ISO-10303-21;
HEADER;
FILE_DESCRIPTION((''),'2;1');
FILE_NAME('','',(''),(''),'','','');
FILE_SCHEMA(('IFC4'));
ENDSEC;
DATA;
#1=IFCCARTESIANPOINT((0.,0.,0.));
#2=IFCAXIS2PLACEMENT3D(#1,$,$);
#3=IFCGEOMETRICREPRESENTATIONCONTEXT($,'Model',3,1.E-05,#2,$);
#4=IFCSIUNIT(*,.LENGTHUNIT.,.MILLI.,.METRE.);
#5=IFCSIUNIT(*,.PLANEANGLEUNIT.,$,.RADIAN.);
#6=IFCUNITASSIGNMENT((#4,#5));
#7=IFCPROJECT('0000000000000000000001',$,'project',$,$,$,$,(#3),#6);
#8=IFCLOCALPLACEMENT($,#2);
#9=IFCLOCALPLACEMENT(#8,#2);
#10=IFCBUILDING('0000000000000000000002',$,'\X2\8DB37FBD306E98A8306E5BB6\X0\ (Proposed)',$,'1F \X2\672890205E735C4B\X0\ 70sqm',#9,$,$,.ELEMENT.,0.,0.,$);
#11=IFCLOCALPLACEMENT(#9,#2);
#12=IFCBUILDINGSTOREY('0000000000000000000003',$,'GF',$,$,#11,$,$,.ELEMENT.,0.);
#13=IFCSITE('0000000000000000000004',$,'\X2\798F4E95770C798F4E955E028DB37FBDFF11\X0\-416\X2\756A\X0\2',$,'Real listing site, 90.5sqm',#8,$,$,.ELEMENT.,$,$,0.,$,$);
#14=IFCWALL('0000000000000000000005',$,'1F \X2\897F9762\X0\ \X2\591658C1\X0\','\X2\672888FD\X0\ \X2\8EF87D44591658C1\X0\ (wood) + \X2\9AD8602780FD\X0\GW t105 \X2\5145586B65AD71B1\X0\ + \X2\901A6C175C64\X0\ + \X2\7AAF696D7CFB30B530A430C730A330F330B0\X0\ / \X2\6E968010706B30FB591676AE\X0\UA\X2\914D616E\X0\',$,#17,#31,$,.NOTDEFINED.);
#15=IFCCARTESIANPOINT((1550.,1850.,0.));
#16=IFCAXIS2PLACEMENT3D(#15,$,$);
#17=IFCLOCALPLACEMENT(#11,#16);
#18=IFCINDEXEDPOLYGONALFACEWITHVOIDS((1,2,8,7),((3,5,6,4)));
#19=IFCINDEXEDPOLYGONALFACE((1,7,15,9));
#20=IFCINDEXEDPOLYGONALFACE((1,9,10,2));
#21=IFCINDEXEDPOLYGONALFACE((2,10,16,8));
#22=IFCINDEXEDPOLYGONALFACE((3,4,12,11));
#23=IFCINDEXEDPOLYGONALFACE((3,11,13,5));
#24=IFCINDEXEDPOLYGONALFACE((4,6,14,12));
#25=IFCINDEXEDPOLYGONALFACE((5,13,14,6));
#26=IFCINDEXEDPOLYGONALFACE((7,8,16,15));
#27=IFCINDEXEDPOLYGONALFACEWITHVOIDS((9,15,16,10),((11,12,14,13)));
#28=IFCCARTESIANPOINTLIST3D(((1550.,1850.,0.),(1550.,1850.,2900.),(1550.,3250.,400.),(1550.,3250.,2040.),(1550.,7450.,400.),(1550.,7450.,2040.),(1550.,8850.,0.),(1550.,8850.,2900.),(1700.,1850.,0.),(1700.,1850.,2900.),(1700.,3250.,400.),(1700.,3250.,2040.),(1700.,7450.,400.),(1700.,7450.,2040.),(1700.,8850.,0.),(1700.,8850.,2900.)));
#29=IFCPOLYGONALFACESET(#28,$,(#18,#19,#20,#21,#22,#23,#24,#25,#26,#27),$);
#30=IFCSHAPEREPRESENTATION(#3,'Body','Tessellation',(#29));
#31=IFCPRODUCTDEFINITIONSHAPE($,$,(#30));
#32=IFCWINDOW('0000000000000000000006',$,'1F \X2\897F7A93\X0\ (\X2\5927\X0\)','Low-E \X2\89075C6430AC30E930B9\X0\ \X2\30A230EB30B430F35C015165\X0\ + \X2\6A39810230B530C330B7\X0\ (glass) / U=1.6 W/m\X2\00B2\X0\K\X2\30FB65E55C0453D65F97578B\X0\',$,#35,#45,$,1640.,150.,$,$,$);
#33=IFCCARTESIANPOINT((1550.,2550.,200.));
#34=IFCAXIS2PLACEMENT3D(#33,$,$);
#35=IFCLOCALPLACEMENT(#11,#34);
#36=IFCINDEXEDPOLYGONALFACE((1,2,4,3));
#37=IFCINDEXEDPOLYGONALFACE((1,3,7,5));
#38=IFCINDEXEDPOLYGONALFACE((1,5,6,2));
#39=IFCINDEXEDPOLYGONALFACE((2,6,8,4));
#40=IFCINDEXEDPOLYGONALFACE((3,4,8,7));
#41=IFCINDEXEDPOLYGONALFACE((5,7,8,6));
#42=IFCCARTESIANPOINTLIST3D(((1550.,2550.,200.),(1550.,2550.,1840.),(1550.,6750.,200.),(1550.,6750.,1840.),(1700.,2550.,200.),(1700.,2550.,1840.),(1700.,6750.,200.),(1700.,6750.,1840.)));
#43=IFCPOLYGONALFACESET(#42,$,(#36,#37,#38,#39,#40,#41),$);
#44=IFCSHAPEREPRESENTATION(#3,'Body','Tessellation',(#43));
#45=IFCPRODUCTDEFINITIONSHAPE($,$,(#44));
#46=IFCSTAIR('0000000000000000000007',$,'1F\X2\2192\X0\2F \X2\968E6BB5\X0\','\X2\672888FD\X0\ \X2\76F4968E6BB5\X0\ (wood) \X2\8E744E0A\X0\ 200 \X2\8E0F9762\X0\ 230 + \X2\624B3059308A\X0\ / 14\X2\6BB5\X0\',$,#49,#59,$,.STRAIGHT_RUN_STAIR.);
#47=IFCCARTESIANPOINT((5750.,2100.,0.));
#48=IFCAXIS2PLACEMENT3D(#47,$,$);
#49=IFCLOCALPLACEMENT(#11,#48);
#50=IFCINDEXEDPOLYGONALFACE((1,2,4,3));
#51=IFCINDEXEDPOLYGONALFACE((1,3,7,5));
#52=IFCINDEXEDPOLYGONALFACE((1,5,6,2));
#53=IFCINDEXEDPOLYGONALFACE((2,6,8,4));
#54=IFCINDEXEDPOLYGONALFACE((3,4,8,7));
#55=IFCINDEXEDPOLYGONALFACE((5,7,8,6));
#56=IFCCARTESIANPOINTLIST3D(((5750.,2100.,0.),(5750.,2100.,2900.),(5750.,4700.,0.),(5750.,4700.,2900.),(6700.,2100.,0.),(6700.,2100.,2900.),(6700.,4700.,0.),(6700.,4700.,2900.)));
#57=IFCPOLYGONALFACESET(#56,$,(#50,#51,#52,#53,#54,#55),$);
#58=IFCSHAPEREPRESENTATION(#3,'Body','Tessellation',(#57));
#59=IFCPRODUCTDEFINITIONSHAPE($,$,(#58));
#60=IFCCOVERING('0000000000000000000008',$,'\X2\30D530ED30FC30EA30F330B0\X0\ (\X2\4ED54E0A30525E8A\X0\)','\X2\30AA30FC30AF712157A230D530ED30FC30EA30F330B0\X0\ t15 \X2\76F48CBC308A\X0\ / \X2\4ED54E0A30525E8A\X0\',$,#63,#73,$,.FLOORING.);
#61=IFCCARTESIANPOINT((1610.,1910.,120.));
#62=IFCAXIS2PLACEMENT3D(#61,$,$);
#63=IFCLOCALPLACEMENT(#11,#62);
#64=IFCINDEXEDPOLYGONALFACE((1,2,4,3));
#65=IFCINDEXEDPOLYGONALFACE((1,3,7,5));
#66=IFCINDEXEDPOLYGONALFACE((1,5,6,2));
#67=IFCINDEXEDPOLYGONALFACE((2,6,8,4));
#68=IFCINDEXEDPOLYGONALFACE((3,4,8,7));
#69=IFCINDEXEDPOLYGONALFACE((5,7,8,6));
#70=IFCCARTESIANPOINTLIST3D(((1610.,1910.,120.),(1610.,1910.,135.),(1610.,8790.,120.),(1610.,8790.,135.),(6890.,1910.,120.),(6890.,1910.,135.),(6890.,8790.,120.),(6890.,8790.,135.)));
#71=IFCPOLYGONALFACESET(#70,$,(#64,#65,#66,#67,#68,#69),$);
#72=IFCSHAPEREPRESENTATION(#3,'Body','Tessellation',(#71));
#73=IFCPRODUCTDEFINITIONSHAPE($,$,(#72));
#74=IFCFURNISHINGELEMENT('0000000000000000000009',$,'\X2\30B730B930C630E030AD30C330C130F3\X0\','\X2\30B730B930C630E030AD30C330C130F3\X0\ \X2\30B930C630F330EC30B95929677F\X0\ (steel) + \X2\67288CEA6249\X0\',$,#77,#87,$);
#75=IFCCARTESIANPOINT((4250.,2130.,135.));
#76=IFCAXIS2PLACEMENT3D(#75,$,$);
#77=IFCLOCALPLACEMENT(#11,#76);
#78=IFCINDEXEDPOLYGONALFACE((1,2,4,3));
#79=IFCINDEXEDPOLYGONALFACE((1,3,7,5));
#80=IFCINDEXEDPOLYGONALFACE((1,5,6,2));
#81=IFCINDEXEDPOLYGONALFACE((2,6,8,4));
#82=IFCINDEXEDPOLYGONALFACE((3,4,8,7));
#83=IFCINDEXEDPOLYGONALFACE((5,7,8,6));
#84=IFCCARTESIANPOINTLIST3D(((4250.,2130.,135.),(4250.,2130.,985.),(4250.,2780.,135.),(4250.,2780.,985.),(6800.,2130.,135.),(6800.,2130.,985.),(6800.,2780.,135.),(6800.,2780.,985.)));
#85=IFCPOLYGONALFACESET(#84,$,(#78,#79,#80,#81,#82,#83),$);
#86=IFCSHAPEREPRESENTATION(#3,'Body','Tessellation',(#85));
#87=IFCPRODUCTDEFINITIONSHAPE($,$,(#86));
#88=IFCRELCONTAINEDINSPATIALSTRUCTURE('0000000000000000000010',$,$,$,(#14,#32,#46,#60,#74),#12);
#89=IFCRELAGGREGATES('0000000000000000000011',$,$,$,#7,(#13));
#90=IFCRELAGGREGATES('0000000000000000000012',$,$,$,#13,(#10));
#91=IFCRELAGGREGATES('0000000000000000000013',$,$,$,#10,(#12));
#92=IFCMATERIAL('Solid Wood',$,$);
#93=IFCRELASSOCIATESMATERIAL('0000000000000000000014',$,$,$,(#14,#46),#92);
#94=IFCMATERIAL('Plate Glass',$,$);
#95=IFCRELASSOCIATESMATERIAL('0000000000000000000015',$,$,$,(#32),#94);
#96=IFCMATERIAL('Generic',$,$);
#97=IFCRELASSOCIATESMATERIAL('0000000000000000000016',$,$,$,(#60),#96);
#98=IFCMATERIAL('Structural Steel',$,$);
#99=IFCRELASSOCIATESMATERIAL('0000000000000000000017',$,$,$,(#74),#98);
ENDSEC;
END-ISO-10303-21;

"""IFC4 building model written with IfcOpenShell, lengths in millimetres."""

from ifc_helpers import new_model, si_unit, frame, frame_2d, origin, place, context, project, spatial, rectangle, extrude, material, element, fill, save


model = new_model("IFC4")

# Units and contexts
model_context = context("Model", 3, precision=1e-05, world=origin())
ifc_project = project(units=[si_unit("LENGTHUNIT", "METRE", prefix="MILLI"), si_unit("PLANEANGLEUNIT", "RADIAN")], contexts=[model_context])

# Site, building, storey
site_placement = place(None, origin())
site = spatial("IfcSite", under=ifc_project, at=site_placement, Name="福井県福井市足羽１-416番2", ObjectType="Real listing site, 90.5sqm", CompositionType="ELEMENT", RefElevation=0.0)
building_placement = place(site_placement, origin())
building = spatial("IfcBuilding", under=site, at=building_placement, Name="足羽の風の家 (Proposed)", ObjectType="1F 木造平屋 70sqm", CompositionType="ELEMENT", ElevationOfRefHeight=0.0, ElevationOfTerrain=0.0)
storey_placement = place(building_placement, origin())
storey = spatial("IfcBuildingStorey", under=building, at=storey_placement, Name="GF", CompositionType="ELEMENT", Elevation=0.0)

# Shared definitions
ifc_material_1 = material(Name="Solid Wood")
ifc_material_2 = material(Name="Generic")

# Shared definitions
ifc_material_3 = material(Name="Plate Glass")

# Wall, opening, window
wall_1_placement = place(storey_placement, frame((1550.0, 1850.0, 0.0)))
wall_1 = element("IfcWall", 1, at=wall_1_placement, inside=storey, material=ifc_material_1, Name="1F 西面 外壁", Description="木製 軸組外壁 (wood) + 高性能GW t105 充填断熱 + 通気層 + 窯業系サイディング / 準耐火・外皮UA配慮", PredefinedType="NOTDEFINED", context=model_context, shape_type="SweptSolid", body=[
    extrude(rectangle(XDim=150.0, YDim=7000.0, at=frame_2d((75.0, 3500.0))), frame((1550.0, 1850.0, 0.0)), (0.0, 0.0, 1.0), 2900.0),
])
opening_1_placement = place(storey_placement, frame((1550.0, 2550.0, 200.0)))
opening_1 = element("IfcOpeningElement", 2, at=opening_1_placement, cuts=wall_1, PredefinedType="NOTDEFINED", context=model_context, shape_type="SweptSolid", body=[
    extrude(rectangle(XDim=150.0, YDim=4200.0, at=frame_2d((75.0, 2100.0))), frame((1550.0, 2550.0, 200.0)), (0.0, 0.0, 1.0), 1640.0),
])
window_1_placement = place(storey_placement, frame((1550.0, 2550.0, 200.0)))
window_1 = element("IfcWindow", 3, at=window_1_placement, inside=storey, material=ifc_material_3, Name="1F 西窓 (大)", Description="Low-E 複層ガラス アルゴン封入 + 樹脂サッシ (glass) / U=1.6 W/m²K・日射取得型", OverallHeight=1640.0, OverallWidth=150.0, context=model_context, shape_type="SweptSolid", body=[
    extrude(rectangle(XDim=150.0, YDim=4200.0, at=frame_2d((75.0, 2100.0))), frame((1550.0, 2550.0, 200.0)), (0.0, 0.0, 1.0), 1640.0),
])
fill(opening_1, window_1)

# Stair
stair_placement = place(storey_placement, frame((5750.0, 2100.0, 0.0)))
element("IfcStair", 4, at=stair_placement, inside=storey, material=ifc_material_1, Name="1F→2F 階段", Description="木製 直階段 (wood) 蹴上 200 踏面 230 + 手すり / 14段", PredefinedType="STRAIGHT_RUN_STAIR", context=model_context, shape_type="SweptSolid", body=[
    extrude(rectangle(XDim=950.0, YDim=2600.0, at=frame_2d((475.0, 1300.0))), frame((5750.0, 2100.0, 0.0)), (0.0, 0.0, 1.0), 2900.0),
])

# Covering
covering_placement = place(storey_placement, frame((1610.0, 1910.0, 120.0)))
element("IfcCovering", 5, at=covering_placement, inside=storey, material=ifc_material_2, Name="フローリング (仕上げ床)", Description="オーク無垢フローリング t15 直貼り / 仕上げ床", PredefinedType="FLOORING", context=model_context, shape_type="SweptSolid", body=[
    extrude(rectangle(XDim=5280.0, YDim=6880.0, at=frame_2d((2640.0, 3440.0))), frame((1610.0, 1910.0, 120.0)), (0.0, 0.0, 1.0), 15.0),
])

# Furnishing element
ifc_material_4 = material(Name="Structural Steel")
furnishing_placement = place(storey_placement, frame((4250.0, 2130.0, 135.0)))
element("IfcFurnishingElement", 6, at=furnishing_placement, inside=storey, material=ifc_material_4, Name="システムキッチン", Description="システムキッチン ステンレス天板 (steel) + 木質扉", context=model_context, shape_type="SweptSolid", body=[
    extrude(rectangle(XDim=2550.0, YDim=650.0, at=frame_2d((1275.0, 325.0))), frame((4250.0, 2130.0, 135.0)), (0.0, 0.0, 1.0), 850.0),
])

save(model, "model.ifc")
